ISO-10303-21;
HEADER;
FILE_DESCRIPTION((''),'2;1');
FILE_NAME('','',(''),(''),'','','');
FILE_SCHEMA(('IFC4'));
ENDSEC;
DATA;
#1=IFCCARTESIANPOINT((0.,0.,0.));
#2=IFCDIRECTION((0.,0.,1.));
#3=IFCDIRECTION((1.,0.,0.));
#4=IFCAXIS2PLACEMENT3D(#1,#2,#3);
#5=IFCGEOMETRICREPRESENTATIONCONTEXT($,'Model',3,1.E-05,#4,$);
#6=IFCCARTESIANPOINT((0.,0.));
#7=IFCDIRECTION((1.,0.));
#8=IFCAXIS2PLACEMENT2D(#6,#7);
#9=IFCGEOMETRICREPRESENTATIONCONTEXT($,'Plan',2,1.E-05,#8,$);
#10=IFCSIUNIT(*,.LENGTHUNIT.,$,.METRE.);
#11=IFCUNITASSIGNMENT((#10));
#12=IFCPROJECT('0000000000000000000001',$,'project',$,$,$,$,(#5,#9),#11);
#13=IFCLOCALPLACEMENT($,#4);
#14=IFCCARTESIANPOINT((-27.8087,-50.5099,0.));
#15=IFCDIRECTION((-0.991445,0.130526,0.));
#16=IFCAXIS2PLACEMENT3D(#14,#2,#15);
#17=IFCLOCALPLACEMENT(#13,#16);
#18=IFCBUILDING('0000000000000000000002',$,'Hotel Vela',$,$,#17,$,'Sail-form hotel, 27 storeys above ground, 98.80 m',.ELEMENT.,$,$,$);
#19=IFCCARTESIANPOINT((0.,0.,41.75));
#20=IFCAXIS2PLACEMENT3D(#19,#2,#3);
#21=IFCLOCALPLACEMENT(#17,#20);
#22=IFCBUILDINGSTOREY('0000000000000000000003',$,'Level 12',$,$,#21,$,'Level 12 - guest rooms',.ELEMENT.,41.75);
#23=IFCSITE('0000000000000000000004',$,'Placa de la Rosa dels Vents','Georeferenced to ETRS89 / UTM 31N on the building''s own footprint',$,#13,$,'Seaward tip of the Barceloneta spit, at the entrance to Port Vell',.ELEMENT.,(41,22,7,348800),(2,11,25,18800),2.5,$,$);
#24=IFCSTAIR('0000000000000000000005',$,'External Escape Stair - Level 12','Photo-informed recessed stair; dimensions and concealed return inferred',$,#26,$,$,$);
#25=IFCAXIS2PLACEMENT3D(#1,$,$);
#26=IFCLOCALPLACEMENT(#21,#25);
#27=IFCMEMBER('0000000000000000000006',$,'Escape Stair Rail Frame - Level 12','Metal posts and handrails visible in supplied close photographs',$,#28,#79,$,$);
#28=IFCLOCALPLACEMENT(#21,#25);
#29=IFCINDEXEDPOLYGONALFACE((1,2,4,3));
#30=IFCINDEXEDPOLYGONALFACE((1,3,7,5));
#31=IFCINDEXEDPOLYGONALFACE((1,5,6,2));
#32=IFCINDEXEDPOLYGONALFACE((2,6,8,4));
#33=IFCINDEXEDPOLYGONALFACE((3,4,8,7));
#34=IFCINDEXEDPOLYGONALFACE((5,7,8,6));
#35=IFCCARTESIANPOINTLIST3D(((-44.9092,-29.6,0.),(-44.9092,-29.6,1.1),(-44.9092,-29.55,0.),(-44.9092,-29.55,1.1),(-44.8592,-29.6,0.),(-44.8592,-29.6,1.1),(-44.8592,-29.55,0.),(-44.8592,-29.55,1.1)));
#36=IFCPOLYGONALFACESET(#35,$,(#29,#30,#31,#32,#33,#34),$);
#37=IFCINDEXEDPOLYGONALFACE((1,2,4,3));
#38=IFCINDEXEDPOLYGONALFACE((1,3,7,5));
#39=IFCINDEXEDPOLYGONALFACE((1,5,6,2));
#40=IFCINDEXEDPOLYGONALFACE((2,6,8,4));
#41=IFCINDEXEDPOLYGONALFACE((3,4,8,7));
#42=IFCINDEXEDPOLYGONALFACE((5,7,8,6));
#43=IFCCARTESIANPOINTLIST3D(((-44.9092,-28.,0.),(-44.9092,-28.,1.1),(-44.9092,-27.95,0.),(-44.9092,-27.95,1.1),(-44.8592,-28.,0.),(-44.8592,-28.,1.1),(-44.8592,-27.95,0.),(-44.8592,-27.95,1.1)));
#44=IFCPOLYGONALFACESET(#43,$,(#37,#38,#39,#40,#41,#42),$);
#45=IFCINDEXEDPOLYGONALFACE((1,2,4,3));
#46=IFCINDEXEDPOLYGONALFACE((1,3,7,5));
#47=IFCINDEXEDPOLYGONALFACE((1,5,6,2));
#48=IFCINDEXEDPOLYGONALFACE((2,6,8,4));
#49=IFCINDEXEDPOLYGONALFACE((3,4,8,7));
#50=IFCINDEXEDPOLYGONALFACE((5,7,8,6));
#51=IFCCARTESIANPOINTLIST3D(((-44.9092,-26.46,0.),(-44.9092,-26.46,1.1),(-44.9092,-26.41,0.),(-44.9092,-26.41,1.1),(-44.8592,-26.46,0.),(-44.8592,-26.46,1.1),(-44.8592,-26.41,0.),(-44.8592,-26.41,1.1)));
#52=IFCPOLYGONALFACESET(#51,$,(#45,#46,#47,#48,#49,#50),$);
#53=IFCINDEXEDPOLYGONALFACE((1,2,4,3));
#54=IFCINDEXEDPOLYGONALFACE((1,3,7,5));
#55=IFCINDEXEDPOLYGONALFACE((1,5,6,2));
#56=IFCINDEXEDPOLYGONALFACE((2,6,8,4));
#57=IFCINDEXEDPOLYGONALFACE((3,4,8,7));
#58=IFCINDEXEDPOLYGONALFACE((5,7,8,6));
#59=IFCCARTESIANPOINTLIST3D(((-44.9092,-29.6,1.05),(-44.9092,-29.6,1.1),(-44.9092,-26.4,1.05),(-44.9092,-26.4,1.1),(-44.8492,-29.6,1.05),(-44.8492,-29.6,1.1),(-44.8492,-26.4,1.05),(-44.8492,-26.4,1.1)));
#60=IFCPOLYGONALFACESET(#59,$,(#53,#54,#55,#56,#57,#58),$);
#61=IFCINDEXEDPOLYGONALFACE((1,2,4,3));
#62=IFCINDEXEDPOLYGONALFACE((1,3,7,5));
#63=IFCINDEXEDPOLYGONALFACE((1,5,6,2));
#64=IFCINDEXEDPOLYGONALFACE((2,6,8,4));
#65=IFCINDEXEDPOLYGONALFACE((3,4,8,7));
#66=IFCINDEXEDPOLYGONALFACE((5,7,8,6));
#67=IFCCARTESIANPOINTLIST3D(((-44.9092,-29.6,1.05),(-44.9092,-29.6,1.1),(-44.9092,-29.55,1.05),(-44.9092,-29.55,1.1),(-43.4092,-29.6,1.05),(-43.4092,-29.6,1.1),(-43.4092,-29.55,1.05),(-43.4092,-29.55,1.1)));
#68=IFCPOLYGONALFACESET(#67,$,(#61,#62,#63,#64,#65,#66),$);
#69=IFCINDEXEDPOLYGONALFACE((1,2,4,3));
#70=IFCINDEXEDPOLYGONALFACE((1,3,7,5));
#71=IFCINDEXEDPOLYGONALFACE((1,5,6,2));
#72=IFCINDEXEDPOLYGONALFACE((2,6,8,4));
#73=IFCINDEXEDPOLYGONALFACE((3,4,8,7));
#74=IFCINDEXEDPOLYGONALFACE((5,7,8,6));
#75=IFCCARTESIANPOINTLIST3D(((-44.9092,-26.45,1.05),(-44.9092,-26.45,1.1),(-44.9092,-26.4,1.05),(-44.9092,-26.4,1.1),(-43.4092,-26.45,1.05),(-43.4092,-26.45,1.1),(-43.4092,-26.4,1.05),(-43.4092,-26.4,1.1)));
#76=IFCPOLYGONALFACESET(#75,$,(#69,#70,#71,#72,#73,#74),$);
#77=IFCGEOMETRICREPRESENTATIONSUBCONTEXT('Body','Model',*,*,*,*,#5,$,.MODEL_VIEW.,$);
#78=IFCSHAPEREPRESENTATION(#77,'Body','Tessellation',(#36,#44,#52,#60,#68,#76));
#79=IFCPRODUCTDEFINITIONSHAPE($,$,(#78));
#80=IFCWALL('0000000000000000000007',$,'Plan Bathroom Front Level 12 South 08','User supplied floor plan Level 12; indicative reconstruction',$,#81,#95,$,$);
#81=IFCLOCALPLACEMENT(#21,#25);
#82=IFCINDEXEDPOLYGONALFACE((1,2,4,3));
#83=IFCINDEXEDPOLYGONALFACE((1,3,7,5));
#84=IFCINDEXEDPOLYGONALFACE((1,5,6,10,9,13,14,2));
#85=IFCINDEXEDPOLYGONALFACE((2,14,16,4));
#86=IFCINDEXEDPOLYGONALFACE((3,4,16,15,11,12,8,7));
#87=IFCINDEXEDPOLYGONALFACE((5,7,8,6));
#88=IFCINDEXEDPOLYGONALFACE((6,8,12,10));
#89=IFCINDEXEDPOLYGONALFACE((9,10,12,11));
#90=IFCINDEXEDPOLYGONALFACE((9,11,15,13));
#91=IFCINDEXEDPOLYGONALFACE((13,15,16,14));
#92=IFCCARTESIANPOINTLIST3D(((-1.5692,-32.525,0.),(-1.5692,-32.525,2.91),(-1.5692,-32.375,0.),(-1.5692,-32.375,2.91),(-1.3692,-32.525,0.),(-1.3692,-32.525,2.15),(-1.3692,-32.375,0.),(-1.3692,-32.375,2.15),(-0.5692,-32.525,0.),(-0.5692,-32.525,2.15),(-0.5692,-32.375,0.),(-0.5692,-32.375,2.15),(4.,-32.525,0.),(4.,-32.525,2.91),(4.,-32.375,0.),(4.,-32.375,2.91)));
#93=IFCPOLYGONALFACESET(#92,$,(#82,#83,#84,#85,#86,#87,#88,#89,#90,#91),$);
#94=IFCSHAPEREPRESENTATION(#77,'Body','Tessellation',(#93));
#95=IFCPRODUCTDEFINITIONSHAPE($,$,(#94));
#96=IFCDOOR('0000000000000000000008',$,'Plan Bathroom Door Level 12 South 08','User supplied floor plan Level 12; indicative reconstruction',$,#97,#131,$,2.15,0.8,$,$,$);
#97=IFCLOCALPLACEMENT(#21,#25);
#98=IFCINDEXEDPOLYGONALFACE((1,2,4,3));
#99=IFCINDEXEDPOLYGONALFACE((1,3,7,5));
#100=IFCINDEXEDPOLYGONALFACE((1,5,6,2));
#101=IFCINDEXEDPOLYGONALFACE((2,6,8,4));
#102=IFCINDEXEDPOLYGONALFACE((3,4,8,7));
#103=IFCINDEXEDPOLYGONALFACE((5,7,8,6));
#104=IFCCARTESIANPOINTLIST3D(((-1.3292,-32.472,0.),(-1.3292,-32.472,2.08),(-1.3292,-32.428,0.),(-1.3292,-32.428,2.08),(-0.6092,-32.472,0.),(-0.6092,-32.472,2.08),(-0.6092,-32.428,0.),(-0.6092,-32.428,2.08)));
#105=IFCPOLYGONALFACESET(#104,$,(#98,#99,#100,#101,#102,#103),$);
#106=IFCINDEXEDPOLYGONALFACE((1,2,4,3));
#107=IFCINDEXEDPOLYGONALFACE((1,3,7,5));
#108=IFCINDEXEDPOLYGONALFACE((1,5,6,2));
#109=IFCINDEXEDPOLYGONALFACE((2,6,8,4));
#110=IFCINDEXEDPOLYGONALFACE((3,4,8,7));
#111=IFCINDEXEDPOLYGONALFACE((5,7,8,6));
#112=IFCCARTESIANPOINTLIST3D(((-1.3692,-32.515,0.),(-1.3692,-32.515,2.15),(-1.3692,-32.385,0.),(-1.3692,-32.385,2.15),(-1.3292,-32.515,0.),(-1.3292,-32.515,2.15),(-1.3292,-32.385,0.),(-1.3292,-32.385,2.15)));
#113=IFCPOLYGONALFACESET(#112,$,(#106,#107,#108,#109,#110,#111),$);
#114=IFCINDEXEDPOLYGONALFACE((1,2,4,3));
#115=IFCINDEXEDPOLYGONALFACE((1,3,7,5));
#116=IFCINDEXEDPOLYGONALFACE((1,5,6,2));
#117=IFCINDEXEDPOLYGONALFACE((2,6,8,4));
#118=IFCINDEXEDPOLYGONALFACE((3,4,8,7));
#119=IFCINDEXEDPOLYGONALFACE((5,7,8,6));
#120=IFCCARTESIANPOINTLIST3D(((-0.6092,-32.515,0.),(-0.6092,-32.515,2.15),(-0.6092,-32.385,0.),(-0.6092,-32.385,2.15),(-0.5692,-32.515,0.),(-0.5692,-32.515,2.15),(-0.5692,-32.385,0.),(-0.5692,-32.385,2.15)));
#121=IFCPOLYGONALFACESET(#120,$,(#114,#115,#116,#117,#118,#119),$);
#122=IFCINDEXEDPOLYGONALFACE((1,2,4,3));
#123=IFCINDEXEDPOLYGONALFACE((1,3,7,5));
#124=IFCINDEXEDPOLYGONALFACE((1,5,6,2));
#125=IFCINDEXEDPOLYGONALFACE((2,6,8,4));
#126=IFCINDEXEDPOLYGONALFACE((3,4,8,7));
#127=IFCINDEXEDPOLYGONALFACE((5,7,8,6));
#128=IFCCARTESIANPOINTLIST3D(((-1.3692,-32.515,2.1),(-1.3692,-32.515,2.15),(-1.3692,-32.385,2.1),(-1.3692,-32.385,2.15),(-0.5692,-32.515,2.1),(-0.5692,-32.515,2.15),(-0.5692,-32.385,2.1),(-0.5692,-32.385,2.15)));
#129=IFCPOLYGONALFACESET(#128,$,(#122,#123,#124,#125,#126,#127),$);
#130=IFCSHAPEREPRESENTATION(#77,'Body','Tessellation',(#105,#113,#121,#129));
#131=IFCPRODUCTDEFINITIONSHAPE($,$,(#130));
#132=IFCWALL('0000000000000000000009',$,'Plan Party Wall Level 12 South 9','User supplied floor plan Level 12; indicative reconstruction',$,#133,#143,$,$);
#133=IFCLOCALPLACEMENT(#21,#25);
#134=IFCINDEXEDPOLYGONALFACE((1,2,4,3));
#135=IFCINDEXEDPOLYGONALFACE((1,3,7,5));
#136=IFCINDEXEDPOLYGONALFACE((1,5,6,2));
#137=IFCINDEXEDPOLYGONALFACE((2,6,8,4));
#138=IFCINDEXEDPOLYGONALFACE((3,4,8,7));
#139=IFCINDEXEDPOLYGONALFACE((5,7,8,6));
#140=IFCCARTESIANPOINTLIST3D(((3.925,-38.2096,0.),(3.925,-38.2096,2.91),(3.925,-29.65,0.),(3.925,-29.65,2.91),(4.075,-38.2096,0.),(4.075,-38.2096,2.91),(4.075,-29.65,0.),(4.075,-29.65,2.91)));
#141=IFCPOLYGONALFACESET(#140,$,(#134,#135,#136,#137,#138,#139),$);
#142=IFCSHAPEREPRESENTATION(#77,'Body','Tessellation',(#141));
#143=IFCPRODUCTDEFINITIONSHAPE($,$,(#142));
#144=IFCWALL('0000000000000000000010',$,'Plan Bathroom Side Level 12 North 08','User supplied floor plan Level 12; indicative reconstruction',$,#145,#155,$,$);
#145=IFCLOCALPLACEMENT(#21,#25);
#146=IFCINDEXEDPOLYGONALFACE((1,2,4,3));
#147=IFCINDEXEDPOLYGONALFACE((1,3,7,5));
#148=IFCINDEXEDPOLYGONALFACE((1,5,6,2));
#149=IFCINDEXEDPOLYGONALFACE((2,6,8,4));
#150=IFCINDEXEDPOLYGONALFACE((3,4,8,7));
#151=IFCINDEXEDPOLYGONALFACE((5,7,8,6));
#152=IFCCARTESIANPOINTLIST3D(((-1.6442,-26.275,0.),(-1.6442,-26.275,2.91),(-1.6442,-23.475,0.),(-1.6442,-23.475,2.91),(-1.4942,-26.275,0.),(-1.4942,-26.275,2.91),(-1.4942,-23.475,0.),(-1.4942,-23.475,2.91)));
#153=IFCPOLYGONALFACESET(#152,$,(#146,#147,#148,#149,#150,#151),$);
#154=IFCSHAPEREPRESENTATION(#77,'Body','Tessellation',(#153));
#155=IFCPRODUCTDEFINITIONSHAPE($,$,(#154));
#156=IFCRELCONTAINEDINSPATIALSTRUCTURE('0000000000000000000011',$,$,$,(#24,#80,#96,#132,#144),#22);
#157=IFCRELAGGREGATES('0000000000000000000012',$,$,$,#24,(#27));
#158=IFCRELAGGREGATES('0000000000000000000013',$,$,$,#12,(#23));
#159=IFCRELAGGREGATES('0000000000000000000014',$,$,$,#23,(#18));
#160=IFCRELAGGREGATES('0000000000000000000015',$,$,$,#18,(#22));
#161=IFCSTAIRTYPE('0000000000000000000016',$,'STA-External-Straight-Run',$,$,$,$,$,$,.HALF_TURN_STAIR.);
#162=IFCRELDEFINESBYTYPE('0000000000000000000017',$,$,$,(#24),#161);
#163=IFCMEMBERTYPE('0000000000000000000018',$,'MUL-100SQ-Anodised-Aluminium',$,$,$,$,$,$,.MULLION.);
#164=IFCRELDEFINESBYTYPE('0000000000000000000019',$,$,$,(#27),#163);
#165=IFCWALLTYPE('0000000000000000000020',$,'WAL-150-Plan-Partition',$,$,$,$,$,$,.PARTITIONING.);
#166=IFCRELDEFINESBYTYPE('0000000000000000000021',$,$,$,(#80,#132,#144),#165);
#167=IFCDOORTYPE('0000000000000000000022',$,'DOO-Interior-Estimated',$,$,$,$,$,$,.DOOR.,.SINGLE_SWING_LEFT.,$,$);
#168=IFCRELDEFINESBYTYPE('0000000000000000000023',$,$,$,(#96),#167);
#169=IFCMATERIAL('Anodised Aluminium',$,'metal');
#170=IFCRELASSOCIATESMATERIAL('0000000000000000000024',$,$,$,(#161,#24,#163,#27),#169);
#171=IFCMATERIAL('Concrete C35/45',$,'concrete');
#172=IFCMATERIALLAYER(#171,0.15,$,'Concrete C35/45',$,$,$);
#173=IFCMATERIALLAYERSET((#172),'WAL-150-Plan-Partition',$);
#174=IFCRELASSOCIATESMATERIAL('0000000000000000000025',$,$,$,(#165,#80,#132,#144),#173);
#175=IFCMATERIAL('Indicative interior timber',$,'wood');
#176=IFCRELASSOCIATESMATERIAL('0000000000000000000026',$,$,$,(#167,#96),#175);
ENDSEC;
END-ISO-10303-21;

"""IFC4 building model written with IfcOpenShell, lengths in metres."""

from ifc_helpers import new_model, si_unit, frame, origin_with_axes, origin_2d_with_axis, place, context, subcontext, project, spatial, line, indexed_curve, rectangle, outline, extrude, material, layer, layer_set, layer_usage, material_profile, profile_set, profile_usage, type_object, element, fill, aggregate, save


model = new_model("IFC4")

# Units and contexts
model_context = context("Model", 3, precision=1e-05, world=origin_with_axes())
plan_context = context("Plan", 2, precision=1e-05, world=origin_2d_with_axis())
body_context = subcontext(model_context, "Body", "Model", "MODEL_VIEW")
ifc_project = project(units=[si_unit("LENGTHUNIT", "METRE")], contexts=[model_context, plan_context])

# Site, building, storey
site_placement = place(None, origin_with_axes())
site = spatial("IfcSite", under=ifc_project, at=site_placement, Name="Placa de la Rosa dels Vents", Description="Georeferenced to ETRS89 / UTM 31N on the building's own footprint", LongName="Seaward tip of the Barceloneta spit, at the entrance to Port Vell", CompositionType="ELEMENT", RefLatitude=(41, 22, 7, 348800), RefLongitude=(2, 11, 25, 18800), RefElevation=2.5)
building_placement = place(site_placement, frame((-27.8087, -50.5099, 0.0), z_axis=(0.0, 0.0, 1.0), x_axis=(-0.991445, 0.130526, 0.0)))
building = spatial("IfcBuilding", under=site, at=building_placement, Name="Hotel Vela", LongName="Sail-form hotel, 27 storeys above ground, 98.80 m", CompositionType="ELEMENT")
storey_placement = place(building_placement, frame((0.0, 0.0, 41.75), z_axis=(0.0, 0.0, 1.0), x_axis=(1.0, 0.0, 0.0)))
storey = spatial("IfcBuildingStorey", under=building, at=storey_placement, Name="Level 12", LongName="Level 12 - guest rooms", CompositionType="ELEMENT", Elevation=41.75)

# Stair, member
ifc_material_1 = material(Name="Anodised Aluminium", Category="metal")
stair_type = type_object("IfcStairType", Name="STA-External-Straight-Run", PredefinedType="HALF_TURN_STAIR", material=ifc_material_1)
stair_placement = place(storey_placement, frame((0.0, 0.0, -41.75), z_axis=(0.0, 0.0, 1.0), x_axis=(1.0, 0.0, 0.0)))
stair = element("IfcStair", 1, at=stair_placement, inside=storey, type_object=stair_type, material=ifc_material_1, Name="External Escape Stair - Level 12", Description="Photo-informed recessed stair; dimensions and concealed return inferred")
ifc_material_profile = material_profile(ifc_material_1, rectangle(XDim=0.1, YDim=0.1))
ifc_profile_set = profile_set([ifc_material_profile], Name="MUL-100SQ-Anodised-Aluminium")
ifc_profile_usage = profile_usage(ifc_profile_set)
member_type = type_object("IfcMemberType", Name="MUL-100SQ-Anodised-Aluminium", PredefinedType="MULLION", material=ifc_profile_set)
member_placement = place(stair_placement, origin_with_axes())
member = element("IfcMember", 2, at=member_placement, type_object=member_type, material=ifc_profile_usage, Name="Escape Stair Rail Frame - Level 12", Description="Metal posts and handrails visible in supplied close photographs", context=body_context, shape_type="SweptSolid", body=[
    extrude(outline(indexed_curve([(0.0, 0.0), (0.05, 0.0), (0.05, 0.05), (0.0, 0.05)], segments=[line(1, 2, 3, 4, 1)])), frame((-44.9092, -29.6, 41.75), z_axis=(0.0, 0.0, 1.0), x_axis=(1.0, 0.0, 0.0)), (0.0, 0.0, 1.0), 1.1),
    extrude(outline(indexed_curve([(0.0, 0.0), (0.05, 0.0), (0.05, 0.05), (0.0, 0.05)], segments=[line(1, 2, 3, 4, 1)])), frame((-44.9092, -28.0, 41.75), z_axis=(0.0, 0.0, 1.0), x_axis=(1.0, 0.0, 0.0)), (0.0, 0.0, 1.0), 1.1),
    extrude(outline(indexed_curve([(0.0, 0.0), (0.05, 0.0), (0.05, 0.05), (0.0, 0.05)], segments=[line(1, 2, 3, 4, 1)])), frame((-44.9092, -26.46, 41.75), z_axis=(0.0, 0.0, 1.0), x_axis=(1.0, 0.0, 0.0)), (0.0, 0.0, 1.0), 1.1),
    extrude(outline(indexed_curve([(0.0, 0.0), (0.06, 0.0), (0.06, 3.2), (0.0, 3.2)], segments=[line(1, 2, 3, 4, 1)])), frame((-44.9092, -29.6, 42.8), z_axis=(0.0, 0.0, 1.0), x_axis=(1.0, 0.0, 0.0)), (0.0, 0.0, 1.0), 0.05),
    extrude(outline(indexed_curve([(0.0, 0.0), (1.5, 0.0), (1.5, 0.05), (0.0, 0.05)], segments=[line(1, 2, 3, 4, 1)])), frame((-44.9092, -29.6, 42.8), z_axis=(0.0, 0.0, 1.0), x_axis=(1.0, 0.0, 0.0)), (0.0, 0.0, 1.0), 0.05),
    extrude(outline(indexed_curve([(0.0, 0.0), (1.5, 0.0), (1.5, 0.05), (0.0, 0.05)], segments=[line(1, 2, 3, 4, 1)])), frame((-44.9092, -26.45, 42.8), z_axis=(0.0, 0.0, 1.0), x_axis=(1.0, 0.0, 0.0)), (0.0, 0.0, 1.0), 0.05),
])

# Wall, opening, door
ifc_material_2 = material(Name="Concrete C35/45", Category="concrete")
ifc_layer = layer(ifc_material_2, 0.15, Name="Concrete C35/45")
ifc_layer_set = layer_set([ifc_layer], Name="WAL-150-Plan-Partition")
ifc_layer_usage_1 = layer_usage(ifc_layer_set, "AXIS2", "POSITIVE", 0.0)
wall_type = type_object("IfcWallType", Name="WAL-150-Plan-Partition", PredefinedType="PARTITIONING", material=ifc_layer_set)
wall_1_placement = place(storey_placement, frame((-1.5692, -32.525, 0.0), z_axis=(0.0, 0.0, 1.0), x_axis=(1.0, 0.0, 0.0)))
wall_1 = element("IfcWall", 3, at=wall_1_placement, inside=storey, type_object=wall_type, material=ifc_layer_usage_1, Name="Plan Bathroom Front Level 12 South 08", Description="User supplied floor plan Level 12; indicative reconstruction", context=body_context, shape_type="SweptSolid", body=[
    extrude(outline(indexed_curve([(0.0, 0.0), (5.5692, 0.0), (5.5692, 0.15), (0.0, 0.15)], segments=[line(1, 2, 3, 4, 1)])), origin_with_axes(), (0.0, 0.0, 1.0), 2.91),
])
opening_1_placement = place(wall_1_placement, frame((0.2, -0.085, 0.0), z_axis=(0.0, 0.0, 1.0), x_axis=(1.0, 0.0, 0.0)))
opening_1 = element("IfcOpeningElement", 4, at=opening_1_placement, cuts=wall_1, PredefinedType="OPENING", context=body_context, shape_type="SweptSolid", body=[
    extrude(outline(indexed_curve([(0.0, 0.0), (0.8, 0.0), (0.8, 0.32), (0.0, 0.32)], segments=[line(1, 2, 3, 4, 1)])), origin_with_axes(), (0.0, 0.0, 1.0), 2.15),
])
ifc_material_3 = material(Name="Indicative interior timber", Category="wood")
door_type = type_object("IfcDoorType", Name="DOO-Interior-Estimated", OperationType="SINGLE_SWING_LEFT", PredefinedType="DOOR", material=ifc_material_3)
door_1_placement = place(storey_placement, frame((0.0, 0.0, -41.75), z_axis=(0.0, 0.0, 1.0), x_axis=(1.0, 0.0, 0.0)))
door_1 = element("IfcDoor", 5, at=door_1_placement, inside=storey, type_object=door_type, material=ifc_material_3, Name="Plan Bathroom Door Level 12 South 08", Description="User supplied floor plan Level 12; indicative reconstruction", OverallHeight=2.15, OverallWidth=0.8, context=body_context, shape_type="SweptSolid", body=[
    extrude(outline(indexed_curve([(0.0, 0.0), (0.72, 0.0), (0.72, 0.044), (0.0, 0.044)], segments=[line(1, 2, 3, 4, 1)])), frame((-1.3292, -32.472, 41.75), z_axis=(0.0, 0.0, 1.0), x_axis=(1.0, 0.0, 0.0)), (0.0, 0.0, 1.0), 2.08),
    extrude(outline(indexed_curve([(0.0, 0.0), (0.04, 0.0), (0.04, 0.13), (0.0, 0.13)], segments=[line(1, 2, 3, 4, 1)])), frame((-1.3692, -32.515, 41.75), z_axis=(0.0, 0.0, 1.0), x_axis=(1.0, 0.0, 0.0)), (0.0, 0.0, 1.0), 2.15),
    extrude(outline(indexed_curve([(0.0, 0.0), (0.04, 0.0), (0.04, 0.13), (0.0, 0.13)], segments=[line(1, 2, 3, 4, 1)])), frame((-0.6092, -32.515, 41.75), z_axis=(0.0, 0.0, 1.0), x_axis=(1.0, 0.0, 0.0)), (0.0, 0.0, 1.0), 2.15),
    extrude(outline(indexed_curve([(0.0, 0.0), (0.8, 0.0), (0.8, 0.13), (0.0, 0.13)], segments=[line(1, 2, 3, 4, 1)])), frame((-1.3692, -32.515, 43.85), z_axis=(0.0, 0.0, 1.0), x_axis=(1.0, 0.0, 0.0)), (0.0, 0.0, 1.0), 0.05),
])
fill(opening_1, door_1)

# Walls
ifc_layer_usage_2 = layer_usage(ifc_layer_set, "AXIS2", "POSITIVE", 0.0)
wall_2_placement = place(storey_placement, frame((3.925, -38.2096, 0.0), z_axis=(0.0, 0.0, 1.0), x_axis=(1.0, 0.0, 0.0)))
element("IfcWall", 6, at=wall_2_placement, inside=storey, type_object=wall_type, material=ifc_layer_usage_2, Name="Plan Party Wall Level 12 South 9", Description="User supplied floor plan Level 12; indicative reconstruction", context=body_context, shape_type="SweptSolid", body=[
    extrude(outline(indexed_curve([(0.0, 0.0), (0.15, 0.0), (0.15, 8.5596), (0.0, 8.5596)], segments=[line(1, 2, 3, 4, 1)])), origin_with_axes(), (0.0, 0.0, 1.0), 2.91),
])
ifc_layer_usage_3 = layer_usage(ifc_layer_set, "AXIS2", "POSITIVE", 0.0)
wall_3_placement = place(storey_placement, frame((-1.6442, -26.275, 0.0), z_axis=(0.0, 0.0, 1.0), x_axis=(1.0, 0.0, 0.0)))
element("IfcWall", 7, at=wall_3_placement, inside=storey, type_object=wall_type, material=ifc_layer_usage_3, Name="Plan Bathroom Side Level 12 North 08", Description="User supplied floor plan Level 12; indicative reconstruction", context=body_context, shape_type="SweptSolid", body=[
    extrude(outline(indexed_curve([(0.0, 0.0), (0.15, 0.0), (0.15, 2.8), (0.0, 2.8)], segments=[line(1, 2, 3, 4, 1)])), origin_with_axes(), (0.0, 0.0, 1.0), 2.91),
])

aggregate(stair, [member])

save(model, "model.ifc")
